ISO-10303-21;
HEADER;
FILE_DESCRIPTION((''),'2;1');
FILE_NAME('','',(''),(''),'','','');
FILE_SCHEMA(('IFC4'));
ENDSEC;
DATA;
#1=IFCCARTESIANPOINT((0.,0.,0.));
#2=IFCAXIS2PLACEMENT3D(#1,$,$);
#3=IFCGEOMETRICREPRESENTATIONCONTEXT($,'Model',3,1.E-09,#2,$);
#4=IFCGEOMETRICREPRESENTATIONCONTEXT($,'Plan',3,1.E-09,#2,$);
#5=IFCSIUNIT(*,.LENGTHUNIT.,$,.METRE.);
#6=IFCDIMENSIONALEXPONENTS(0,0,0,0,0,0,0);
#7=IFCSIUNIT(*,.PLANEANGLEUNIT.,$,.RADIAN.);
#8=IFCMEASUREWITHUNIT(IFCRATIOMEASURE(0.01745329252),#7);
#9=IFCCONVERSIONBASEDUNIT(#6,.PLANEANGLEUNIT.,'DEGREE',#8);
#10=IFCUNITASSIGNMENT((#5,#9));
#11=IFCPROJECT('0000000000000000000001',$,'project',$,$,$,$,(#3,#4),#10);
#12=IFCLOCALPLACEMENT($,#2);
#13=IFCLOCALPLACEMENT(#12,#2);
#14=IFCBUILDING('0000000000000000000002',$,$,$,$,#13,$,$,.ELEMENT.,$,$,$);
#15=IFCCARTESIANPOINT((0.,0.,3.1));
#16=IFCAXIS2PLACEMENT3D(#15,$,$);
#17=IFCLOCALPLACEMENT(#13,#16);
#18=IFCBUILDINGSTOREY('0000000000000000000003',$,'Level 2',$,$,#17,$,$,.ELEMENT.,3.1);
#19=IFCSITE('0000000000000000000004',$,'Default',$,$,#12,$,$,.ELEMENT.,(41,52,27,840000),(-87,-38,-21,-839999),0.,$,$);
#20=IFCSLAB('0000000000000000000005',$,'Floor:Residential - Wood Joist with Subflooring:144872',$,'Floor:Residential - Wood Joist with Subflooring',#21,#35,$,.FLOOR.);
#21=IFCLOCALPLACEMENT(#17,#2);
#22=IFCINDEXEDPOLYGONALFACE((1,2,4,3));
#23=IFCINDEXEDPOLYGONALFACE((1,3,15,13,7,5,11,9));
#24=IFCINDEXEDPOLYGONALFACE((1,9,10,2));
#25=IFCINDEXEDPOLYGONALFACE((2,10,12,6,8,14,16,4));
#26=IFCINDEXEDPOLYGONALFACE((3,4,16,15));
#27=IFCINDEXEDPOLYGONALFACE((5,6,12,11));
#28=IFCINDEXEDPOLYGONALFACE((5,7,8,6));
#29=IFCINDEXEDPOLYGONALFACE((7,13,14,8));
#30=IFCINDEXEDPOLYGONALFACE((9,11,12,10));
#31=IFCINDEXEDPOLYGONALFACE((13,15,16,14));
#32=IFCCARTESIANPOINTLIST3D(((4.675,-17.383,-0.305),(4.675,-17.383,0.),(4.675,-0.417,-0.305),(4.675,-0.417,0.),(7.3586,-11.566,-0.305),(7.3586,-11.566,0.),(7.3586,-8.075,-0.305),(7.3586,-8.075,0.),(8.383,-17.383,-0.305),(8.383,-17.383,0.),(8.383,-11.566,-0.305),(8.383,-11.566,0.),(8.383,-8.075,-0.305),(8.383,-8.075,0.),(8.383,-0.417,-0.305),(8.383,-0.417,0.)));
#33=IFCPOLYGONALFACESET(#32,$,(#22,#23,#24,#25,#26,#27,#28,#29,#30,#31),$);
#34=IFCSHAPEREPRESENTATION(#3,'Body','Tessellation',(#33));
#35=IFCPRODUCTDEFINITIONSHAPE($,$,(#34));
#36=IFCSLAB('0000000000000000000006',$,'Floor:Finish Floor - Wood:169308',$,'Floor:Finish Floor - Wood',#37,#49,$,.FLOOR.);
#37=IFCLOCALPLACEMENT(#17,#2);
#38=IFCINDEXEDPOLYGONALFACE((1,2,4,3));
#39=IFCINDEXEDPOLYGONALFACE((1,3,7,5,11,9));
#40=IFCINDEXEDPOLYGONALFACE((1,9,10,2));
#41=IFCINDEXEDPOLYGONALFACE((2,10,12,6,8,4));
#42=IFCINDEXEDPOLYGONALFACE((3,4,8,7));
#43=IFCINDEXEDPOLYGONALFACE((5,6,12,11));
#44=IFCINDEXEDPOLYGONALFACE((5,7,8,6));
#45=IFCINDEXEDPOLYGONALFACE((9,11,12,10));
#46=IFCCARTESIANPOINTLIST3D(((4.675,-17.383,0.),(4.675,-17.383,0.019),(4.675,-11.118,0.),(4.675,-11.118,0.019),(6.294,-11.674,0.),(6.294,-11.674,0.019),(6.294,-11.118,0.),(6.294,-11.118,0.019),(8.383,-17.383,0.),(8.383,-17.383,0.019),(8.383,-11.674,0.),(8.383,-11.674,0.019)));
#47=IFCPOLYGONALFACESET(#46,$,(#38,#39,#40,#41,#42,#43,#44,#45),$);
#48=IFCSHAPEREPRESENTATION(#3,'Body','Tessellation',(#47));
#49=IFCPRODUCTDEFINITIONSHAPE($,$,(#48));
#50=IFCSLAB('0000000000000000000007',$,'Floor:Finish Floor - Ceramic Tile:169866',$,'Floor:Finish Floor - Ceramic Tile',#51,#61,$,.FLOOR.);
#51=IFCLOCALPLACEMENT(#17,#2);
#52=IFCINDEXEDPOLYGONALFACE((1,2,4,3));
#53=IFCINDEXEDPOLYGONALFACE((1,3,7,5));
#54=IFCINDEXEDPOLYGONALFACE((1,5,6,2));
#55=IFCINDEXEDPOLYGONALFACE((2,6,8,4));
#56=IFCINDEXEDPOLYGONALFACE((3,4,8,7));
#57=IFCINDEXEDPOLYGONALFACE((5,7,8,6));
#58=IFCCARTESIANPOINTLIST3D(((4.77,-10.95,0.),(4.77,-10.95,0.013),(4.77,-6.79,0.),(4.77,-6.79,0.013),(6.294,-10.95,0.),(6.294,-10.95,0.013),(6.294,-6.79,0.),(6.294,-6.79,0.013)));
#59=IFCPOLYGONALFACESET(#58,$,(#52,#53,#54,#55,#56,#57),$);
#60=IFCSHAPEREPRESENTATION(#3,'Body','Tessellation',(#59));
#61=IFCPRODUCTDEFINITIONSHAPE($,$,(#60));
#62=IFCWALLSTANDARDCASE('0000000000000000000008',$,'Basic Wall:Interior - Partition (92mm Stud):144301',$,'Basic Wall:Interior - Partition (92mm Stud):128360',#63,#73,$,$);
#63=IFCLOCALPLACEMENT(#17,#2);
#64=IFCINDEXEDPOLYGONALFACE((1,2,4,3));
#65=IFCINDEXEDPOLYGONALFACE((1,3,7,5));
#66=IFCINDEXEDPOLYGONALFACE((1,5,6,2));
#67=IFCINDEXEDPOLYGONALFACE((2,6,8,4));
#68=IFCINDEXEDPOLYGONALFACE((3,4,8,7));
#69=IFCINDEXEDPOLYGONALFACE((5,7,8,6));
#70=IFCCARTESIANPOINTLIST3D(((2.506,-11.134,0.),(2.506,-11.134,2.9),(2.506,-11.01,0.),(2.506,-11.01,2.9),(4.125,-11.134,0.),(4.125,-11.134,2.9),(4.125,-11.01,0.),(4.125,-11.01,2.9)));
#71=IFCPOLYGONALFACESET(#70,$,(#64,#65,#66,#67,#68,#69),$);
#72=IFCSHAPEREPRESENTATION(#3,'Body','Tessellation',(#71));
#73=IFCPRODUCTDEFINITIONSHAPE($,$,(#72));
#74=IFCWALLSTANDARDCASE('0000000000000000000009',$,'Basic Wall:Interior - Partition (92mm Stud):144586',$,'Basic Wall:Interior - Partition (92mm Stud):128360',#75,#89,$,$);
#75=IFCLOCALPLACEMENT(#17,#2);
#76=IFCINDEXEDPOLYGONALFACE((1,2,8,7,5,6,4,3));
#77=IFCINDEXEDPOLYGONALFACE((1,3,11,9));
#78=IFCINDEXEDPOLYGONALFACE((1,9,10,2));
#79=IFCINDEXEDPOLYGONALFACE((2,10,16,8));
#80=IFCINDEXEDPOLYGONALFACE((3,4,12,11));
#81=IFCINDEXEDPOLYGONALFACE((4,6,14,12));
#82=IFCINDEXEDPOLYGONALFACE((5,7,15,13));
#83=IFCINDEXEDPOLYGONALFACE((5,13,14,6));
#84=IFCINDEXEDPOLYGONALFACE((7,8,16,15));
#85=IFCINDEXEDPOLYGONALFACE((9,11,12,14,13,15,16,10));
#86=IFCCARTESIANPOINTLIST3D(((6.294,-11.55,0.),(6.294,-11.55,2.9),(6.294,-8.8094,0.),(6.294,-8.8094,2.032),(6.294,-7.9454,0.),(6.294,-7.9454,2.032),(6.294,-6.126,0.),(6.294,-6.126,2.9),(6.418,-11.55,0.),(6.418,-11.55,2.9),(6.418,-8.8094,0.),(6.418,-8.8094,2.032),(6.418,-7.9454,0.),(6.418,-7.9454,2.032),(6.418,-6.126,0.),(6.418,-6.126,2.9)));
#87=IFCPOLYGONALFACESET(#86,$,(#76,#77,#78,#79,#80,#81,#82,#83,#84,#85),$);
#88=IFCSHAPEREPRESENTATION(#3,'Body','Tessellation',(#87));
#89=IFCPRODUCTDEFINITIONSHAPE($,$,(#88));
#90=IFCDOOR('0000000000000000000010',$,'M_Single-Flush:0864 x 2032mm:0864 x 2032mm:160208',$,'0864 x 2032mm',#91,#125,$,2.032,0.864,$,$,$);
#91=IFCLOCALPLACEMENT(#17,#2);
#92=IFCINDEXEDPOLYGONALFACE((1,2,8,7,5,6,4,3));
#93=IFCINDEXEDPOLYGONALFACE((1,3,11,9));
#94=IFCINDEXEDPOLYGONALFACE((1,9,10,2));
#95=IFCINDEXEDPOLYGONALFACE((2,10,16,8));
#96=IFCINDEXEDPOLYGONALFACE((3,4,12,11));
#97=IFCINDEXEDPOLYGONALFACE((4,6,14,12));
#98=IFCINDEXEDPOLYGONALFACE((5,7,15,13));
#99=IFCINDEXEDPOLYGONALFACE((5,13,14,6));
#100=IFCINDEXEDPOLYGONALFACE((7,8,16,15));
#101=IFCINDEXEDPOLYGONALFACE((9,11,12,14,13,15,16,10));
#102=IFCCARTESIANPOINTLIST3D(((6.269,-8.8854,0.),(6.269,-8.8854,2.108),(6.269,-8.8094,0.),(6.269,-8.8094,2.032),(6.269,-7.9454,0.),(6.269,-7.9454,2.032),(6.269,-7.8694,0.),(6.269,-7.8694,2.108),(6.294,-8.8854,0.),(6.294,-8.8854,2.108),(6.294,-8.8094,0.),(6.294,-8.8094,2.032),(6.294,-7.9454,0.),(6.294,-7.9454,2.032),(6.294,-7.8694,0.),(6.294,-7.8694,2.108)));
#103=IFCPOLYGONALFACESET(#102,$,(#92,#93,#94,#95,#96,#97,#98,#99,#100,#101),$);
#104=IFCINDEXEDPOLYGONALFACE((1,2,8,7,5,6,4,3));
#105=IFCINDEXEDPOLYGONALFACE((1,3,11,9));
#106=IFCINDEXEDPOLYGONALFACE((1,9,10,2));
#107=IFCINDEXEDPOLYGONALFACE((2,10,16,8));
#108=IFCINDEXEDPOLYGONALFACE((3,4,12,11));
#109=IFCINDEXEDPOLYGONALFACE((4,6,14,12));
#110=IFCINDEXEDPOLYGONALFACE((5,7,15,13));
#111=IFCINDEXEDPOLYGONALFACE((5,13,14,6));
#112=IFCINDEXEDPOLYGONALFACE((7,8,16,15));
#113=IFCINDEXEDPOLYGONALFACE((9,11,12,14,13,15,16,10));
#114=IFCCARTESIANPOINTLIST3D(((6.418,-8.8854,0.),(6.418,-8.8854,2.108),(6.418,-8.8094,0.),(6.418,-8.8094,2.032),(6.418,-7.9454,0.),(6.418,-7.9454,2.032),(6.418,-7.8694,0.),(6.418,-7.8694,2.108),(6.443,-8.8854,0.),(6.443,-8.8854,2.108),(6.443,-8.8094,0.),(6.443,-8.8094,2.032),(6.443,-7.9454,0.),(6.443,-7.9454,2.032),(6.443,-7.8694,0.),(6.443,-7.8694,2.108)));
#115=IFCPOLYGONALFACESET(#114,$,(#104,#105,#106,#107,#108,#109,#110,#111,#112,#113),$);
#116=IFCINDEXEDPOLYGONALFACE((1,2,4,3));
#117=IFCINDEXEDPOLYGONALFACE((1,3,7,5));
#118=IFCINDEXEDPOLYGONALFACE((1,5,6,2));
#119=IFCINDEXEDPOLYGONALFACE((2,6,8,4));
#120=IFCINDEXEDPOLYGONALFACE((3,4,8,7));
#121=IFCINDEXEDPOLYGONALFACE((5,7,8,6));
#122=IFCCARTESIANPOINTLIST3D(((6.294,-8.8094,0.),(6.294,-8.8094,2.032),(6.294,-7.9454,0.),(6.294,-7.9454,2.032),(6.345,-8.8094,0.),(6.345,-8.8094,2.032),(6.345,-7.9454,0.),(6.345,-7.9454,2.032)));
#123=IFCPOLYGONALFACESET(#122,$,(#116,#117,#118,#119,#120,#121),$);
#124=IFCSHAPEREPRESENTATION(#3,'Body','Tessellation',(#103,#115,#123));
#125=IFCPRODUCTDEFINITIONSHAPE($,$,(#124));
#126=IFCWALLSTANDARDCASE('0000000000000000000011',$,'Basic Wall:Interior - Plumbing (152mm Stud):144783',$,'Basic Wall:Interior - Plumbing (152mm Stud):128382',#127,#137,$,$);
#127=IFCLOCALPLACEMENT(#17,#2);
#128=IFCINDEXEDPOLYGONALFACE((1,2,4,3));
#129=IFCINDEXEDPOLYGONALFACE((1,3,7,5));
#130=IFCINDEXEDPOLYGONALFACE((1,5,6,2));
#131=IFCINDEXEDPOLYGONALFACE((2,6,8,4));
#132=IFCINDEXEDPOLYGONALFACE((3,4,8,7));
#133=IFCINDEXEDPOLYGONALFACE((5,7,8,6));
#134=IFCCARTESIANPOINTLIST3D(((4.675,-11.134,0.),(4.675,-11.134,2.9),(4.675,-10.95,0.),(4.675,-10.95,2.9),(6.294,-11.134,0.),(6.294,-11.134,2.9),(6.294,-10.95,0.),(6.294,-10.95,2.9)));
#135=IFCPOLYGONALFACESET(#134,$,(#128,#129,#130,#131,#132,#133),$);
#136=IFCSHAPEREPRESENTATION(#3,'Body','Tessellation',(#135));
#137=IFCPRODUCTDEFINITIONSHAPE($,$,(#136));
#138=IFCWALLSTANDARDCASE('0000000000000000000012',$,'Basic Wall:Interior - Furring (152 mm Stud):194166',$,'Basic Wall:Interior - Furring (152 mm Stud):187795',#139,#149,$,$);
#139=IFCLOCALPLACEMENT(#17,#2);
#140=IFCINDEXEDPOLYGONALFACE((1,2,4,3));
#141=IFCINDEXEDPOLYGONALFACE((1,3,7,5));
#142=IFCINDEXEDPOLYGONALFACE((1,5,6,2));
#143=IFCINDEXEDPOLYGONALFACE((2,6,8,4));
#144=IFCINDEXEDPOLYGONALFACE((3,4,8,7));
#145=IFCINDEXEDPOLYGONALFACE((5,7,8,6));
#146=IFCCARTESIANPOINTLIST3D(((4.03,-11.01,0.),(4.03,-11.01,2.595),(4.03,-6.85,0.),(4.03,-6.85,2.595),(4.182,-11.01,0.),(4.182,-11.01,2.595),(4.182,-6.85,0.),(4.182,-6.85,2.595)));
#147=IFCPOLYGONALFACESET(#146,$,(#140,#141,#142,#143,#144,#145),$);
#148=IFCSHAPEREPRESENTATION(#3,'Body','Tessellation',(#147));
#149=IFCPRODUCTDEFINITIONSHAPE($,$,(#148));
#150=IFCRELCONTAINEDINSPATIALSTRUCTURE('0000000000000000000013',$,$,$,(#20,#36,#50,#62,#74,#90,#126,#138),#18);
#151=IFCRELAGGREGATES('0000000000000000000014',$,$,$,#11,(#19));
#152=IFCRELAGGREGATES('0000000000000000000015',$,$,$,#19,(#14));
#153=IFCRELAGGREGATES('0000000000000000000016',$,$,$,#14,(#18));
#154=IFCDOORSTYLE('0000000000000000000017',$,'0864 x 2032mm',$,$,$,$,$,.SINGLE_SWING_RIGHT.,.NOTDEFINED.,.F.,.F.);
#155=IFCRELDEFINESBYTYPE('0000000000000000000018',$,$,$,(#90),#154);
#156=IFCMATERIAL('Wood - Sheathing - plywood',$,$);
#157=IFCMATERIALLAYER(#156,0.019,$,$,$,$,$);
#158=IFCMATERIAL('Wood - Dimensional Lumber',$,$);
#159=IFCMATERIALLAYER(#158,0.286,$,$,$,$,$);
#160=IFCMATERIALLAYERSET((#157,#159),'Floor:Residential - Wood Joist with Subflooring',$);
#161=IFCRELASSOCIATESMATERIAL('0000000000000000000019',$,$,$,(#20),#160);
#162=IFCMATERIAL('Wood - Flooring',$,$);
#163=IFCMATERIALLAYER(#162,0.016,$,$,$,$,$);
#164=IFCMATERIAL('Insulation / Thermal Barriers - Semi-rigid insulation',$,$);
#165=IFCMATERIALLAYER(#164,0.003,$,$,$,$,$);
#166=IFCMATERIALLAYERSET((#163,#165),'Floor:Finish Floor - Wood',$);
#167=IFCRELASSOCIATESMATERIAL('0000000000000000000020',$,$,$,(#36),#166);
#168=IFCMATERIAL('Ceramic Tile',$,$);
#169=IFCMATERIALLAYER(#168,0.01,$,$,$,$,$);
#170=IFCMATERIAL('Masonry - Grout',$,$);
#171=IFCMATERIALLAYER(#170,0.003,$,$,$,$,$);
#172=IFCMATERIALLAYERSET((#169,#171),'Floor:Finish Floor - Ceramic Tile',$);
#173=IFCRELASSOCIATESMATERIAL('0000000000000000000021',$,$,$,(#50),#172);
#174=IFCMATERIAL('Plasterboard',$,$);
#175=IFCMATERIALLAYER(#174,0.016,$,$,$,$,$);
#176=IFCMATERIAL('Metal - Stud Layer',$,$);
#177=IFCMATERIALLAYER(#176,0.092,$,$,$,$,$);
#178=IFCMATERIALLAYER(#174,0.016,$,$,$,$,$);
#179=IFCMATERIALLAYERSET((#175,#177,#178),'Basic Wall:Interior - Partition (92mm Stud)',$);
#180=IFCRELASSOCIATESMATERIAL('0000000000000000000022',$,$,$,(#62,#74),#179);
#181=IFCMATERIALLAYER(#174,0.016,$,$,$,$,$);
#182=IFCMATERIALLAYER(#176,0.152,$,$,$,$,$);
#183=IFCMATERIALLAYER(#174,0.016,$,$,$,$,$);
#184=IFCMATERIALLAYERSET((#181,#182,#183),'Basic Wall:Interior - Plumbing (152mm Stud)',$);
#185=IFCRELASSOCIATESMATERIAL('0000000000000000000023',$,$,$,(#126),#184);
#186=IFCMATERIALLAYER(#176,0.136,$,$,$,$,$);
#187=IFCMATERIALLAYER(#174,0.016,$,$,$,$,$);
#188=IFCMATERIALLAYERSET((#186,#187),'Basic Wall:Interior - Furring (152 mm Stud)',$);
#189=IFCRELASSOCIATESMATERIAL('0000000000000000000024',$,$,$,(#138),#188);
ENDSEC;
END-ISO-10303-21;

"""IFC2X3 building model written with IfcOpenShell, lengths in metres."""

from ifc_helpers import new_model, entity, si_unit, converted_unit, frame, frame_2d, origin, origin_2d_with_axis, place, context, project, spatial, polyline, rectangle, outline, extrude, source, transform, mapped, material, layer, layer_set, layer_usage, type_object, type_shapes, element, fill, save


model = new_model("IFC2X3")

# Units and contexts
model_context = context("Model", 3, precision=1e-09, world=origin())
plan_context = context("Plan", 3, precision=1e-09, world=origin())
ifc_project = project(units=[si_unit("LENGTHUNIT", "METRE"), converted_unit("PLANEANGLEUNIT", "DEGREE", entity("IfcRatioMeasure", 0.01745329252), si_unit("PLANEANGLEUNIT", "RADIAN"), dimensions=[0, 0, 0, 0, 0, 0, 0])], contexts=[model_context, plan_context])

# Site, building, storey
site_placement = place(None, origin())
site = spatial("IfcSite", under=ifc_project, at=site_placement, Name="Default", CompositionType="ELEMENT", RefLatitude=(41, 52, 27, 840000), RefLongitude=(-87, -38, -21, -839999), RefElevation=0.0)
building_placement = place(site_placement, origin())
building = spatial("IfcBuilding", under=site, at=building_placement, CompositionType="ELEMENT")
storey_placement = place(building_placement, frame((0.0, 0.0, 3.1)))
storey = spatial("IfcBuildingStorey", under=building, at=storey_placement, Name="Level 2", CompositionType="ELEMENT", Elevation=3.1)

# Slabs
ifc_material_1 = material(Name="Wood - Sheathing - plywood")
ifc_layer_1 = layer(ifc_material_1, 0.019)
ifc_material_2 = material(Name="Wood - Dimensional Lumber")
ifc_layer_2 = layer(ifc_material_2, 0.286)
ifc_layer_set_1 = layer_set([ifc_layer_1, ifc_layer_2], Name="Floor:Residential - Wood Joist with Subflooring")
ifc_layer_usage_1 = layer_usage(ifc_layer_set_1, "AXIS3", "POSITIVE", 0.0)
slab_1_placement = place(storey_placement, frame((4.675, -17.383, -0.305)))
element("IfcSlab", 1, at=slab_1_placement, inside=storey, material=ifc_layer_usage_1, Name="Floor:Residential - Wood Joist with Subflooring:144872", ObjectType="Floor:Residential - Wood Joist with Subflooring", PredefinedType="FLOOR", context=model_context, shape_type="SweptSolid", body=[
    extrude(outline(polyline([(-1.854, 8.483), (-1.854, 0.825), (-0.8296, 0.825), (-0.8296, -2.666), (-1.854, -2.666), (-1.854, -8.483), (1.854, -8.483), (1.854, 8.483), (-1.854, 8.483)])), frame((1.854, 8.483, 0.305), z_axis=(0.0, 0.0, -1.0), x_axis=(-1.0, 0.0, 0.0)), (0.0, 0.0, 1.0), 0.305),
])
ifc_material_3 = material(Name="Wood - Flooring")
ifc_layer_3 = layer(ifc_material_3, 0.016)
ifc_material_4 = material(Name="Insulation / Thermal Barriers - Semi-rigid insulation")
ifc_layer_4 = layer(ifc_material_4, 0.003)
ifc_layer_set_2 = layer_set([ifc_layer_3, ifc_layer_4], Name="Floor:Finish Floor - Wood")
ifc_layer_usage_2 = layer_usage(ifc_layer_set_2, "AXIS3", "POSITIVE", 0.0)
slab_2_placement = place(storey_placement, frame((4.675, -17.383, 0.0)))
element("IfcSlab", 2, at=slab_2_placement, inside=storey, material=ifc_layer_usage_2, Name="Floor:Finish Floor - Wood:169308", ObjectType="Floor:Finish Floor - Wood", PredefinedType="FLOOR", context=model_context, shape_type="SweptSolid", body=[
    extrude(outline(polyline([(-1.854, 2.5765), (-1.854, -3.1325), (1.854, -3.1325), (1.854, 3.1325), (0.235, 3.1325), (0.235, 2.5765), (-1.854, 2.5765)])), frame((1.854, 3.1325, 0.019), z_axis=(0.0, 0.0, -1.0), x_axis=(-1.0, 0.0, 0.0)), (0.0, 0.0, 1.0), 0.019),
])
ifc_material_5 = material(Name="Ceramic Tile")
ifc_layer_5 = layer(ifc_material_5, 0.01)
ifc_material_6 = material(Name="Masonry - Grout")
ifc_layer_6 = layer(ifc_material_6, 0.003)
ifc_layer_set_3 = layer_set([ifc_layer_5, ifc_layer_6], Name="Floor:Finish Floor - Ceramic Tile")
ifc_layer_usage_3 = layer_usage(ifc_layer_set_3, "AXIS3", "POSITIVE", 0.0)
slab_3_placement = place(storey_placement, frame((4.77, -10.95, 0.0)))
element("IfcSlab", 3, at=slab_3_placement, inside=storey, material=ifc_layer_usage_3, Name="Floor:Finish Floor - Ceramic Tile:169866", ObjectType="Floor:Finish Floor - Ceramic Tile", PredefinedType="FLOOR", context=model_context, shape_type="SweptSolid", body=[
    extrude(rectangle(XDim=4.16, YDim=1.524, at=frame_2d((0.0, 0.0), x_axis=(0.0, -1.0))), frame((0.762, 2.08, 0.013), z_axis=(0.0, 0.0, -1.0), x_axis=(-1.0, 0.0, 0.0)), (0.0, 0.0, 1.0), 0.013),
])

# Shared definitions
ifc_material_7 = material(Name="Metal - Stud Layer")
ifc_material_8 = material(Name="Plasterboard")

# Wall
ifc_layer_7 = layer(ifc_material_8, 0.016)
ifc_layer_8 = layer(ifc_material_7, 0.092)
ifc_layer_9 = layer(ifc_material_8, 0.016)
ifc_layer_set_4 = layer_set([ifc_layer_7, ifc_layer_8, ifc_layer_9], Name="Basic Wall:Interior - Partition (92mm Stud)")
ifc_layer_usage_4 = layer_usage(ifc_layer_set_4, "AXIS2", "NEGATIVE", 0.062)
wall_1_placement = place(storey_placement, frame((4.125, -11.072, 0.0), z_axis=(0.0, 0.0, 1.0), x_axis=(-1.0, 0.0, 0.0)))
element("IfcWallStandardCase", 4, at=wall_1_placement, inside=storey, material=ifc_layer_usage_4, Name="Basic Wall:Interior - Partition (92mm Stud):144301", ObjectType="Basic Wall:Interior - Partition (92mm Stud):128360", context=model_context, shape_type="SweptSolid", body=[
    extrude(rectangle(XDim=1.619, YDim=0.124, at=frame_2d((0.8095, 0.0), x_axis=(-1.0, 0.0))), origin(), (0.0, 0.0, 1.0), 2.9),
])

# Wall, opening, door
ifc_layer_usage_5 = layer_usage(ifc_layer_set_4, "AXIS2", "NEGATIVE", 0.062)
wall_2_placement = place(storey_placement, frame((6.356, -11.55, 0.0), z_axis=(0.0, 0.0, 1.0), x_axis=(0.0, 1.0, 0.0)))
wall_2 = element("IfcWallStandardCase", 5, at=wall_2_placement, inside=storey, material=ifc_layer_usage_5, Name="Basic Wall:Interior - Partition (92mm Stud):144586", ObjectType="Basic Wall:Interior - Partition (92mm Stud):128360", context=model_context, shape_type="SweptSolid", body=[
    extrude(rectangle(XDim=5.424, YDim=0.124, at=frame_2d((2.712, 0.0), x_axis=(-1.0, 0.0))), origin(), (0.0, 0.0, 1.0), 2.9),
])
opening_1_placement = place(wall_2_placement, frame((2.7406, -0.062, 0.0)))
opening_1 = element("IfcOpeningElement", 6, at=opening_1_placement, cuts=wall_2, ObjectType="Opening", context=model_context, shape_type="SweptSolid", body=[
    extrude(rectangle(XDim=0.864, YDim=2.032, at=frame_2d((1.016, 0.432), x_axis=(0.0, 1.0))), frame((0.0, 0.0, 0.0), z_axis=(0.0, 1.0, 0.0), x_axis=(0.0, 0.0, 1.0)), (0.0, 0.0, 1.0), 0.124),
])
door_style = type_object("IfcDoorStyle", Name="0864 x 2032mm", ConstructionType="NOTDEFINED", OperationType="SINGLE_SWING_RIGHT", ParameterTakesPrecedence=False, Sizeable=False)
shared_shape_1 = source(origin(), model_context, "Body", "SweptSolid", [
    extrude(outline(polyline([(-0.508, -1.073), (0.508, -1.073), (0.508, 1.035), (0.432, 1.035), (0.432, -0.997), (-0.432, -0.997), (-0.432, 1.035), (-0.508, 1.035), (-0.508, -1.073)])), frame((0.432, 0.124, 1.035), z_axis=(0.0, 1.0, 0.0), x_axis=(1.0, 0.0, 0.0)), (0.0, 0.0, 1.0), 0.025),
    extrude(outline(polyline([(-1.073, -0.508), (1.035, -0.508), (1.035, -0.432), (-0.997, -0.432), (-0.997, 0.432), (1.035, 0.432), (1.035, 0.508), (-1.073, 0.508), (-1.073, -0.508)])), frame((0.432, -0.025, 1.035), z_axis=(0.0, 1.0, 0.0), x_axis=(0.0, 0.0, -1.0)), (0.0, 0.0, 1.0), 0.025),
    extrude(rectangle(XDim=0.051, YDim=0.864, at=origin_2d_with_axis()), frame((0.432, 0.0985, 0.0), z_axis=(0.0, 0.0, 1.0), x_axis=(0.0, 1.0, 0.0)), (0.0, 0.0, 1.0), 2.032),
])
type_shapes(door_style, [shared_shape_1])
door_placement = place(opening_1_placement, origin())
door = element("IfcDoor", 7, at=door_placement, inside=storey, type_object=door_style, Name="M_Single-Flush:0864 x 2032mm:0864 x 2032mm:160208", ObjectType="0864 x 2032mm", OverallHeight=2.032, OverallWidth=0.864, context=model_context, shape_type="MappedRepresentation", body=[
    mapped(shared_shape_1, transform((0.0, 0.0, 0.0), scale=1.0)),
])
fill(opening_1, door)

# Walls
ifc_layer_10 = layer(ifc_material_8, 0.016)
ifc_layer_11 = layer(ifc_material_7, 0.152)
ifc_layer_12 = layer(ifc_material_8, 0.016)
ifc_layer_set_5 = layer_set([ifc_layer_10, ifc_layer_11, ifc_layer_12], Name="Basic Wall:Interior - Plumbing (152mm Stud)")
ifc_layer_usage_6 = layer_usage(ifc_layer_set_5, "AXIS2", "NEGATIVE", 0.092)
wall_3_placement = place(storey_placement, frame((6.294, -11.042, 0.0), z_axis=(0.0, 0.0, 1.0), x_axis=(-1.0, 0.0, 0.0)))
element("IfcWallStandardCase", 8, at=wall_3_placement, inside=storey, material=ifc_layer_usage_6, Name="Basic Wall:Interior - Plumbing (152mm Stud):144783", ObjectType="Basic Wall:Interior - Plumbing (152mm Stud):128382", context=model_context, shape_type="SweptSolid", body=[
    extrude(rectangle(XDim=1.619, YDim=0.184, at=frame_2d((0.8095, 0.0), x_axis=(-1.0, 0.0))), origin(), (0.0, 0.0, 1.0), 2.9),
])
ifc_layer_13 = layer(ifc_material_7, 0.136)
ifc_layer_14 = layer(ifc_material_8, 0.016)
ifc_layer_set_6 = layer_set([ifc_layer_13, ifc_layer_14], Name="Basic Wall:Interior - Furring (152 mm Stud)")
ifc_layer_usage_7 = layer_usage(ifc_layer_set_6, "AXIS2", "POSITIVE", -0.076)
wall_4_placement = place(storey_placement, frame((4.106, -11.01, 0.0), z_axis=(0.0, 0.0, 1.0), x_axis=(0.0, 1.0, 0.0)))
element("IfcWallStandardCase", 9, at=wall_4_placement, inside=storey, material=ifc_layer_usage_7, Name="Basic Wall:Interior - Furring (152 mm Stud):194166", ObjectType="Basic Wall:Interior - Furring (152 mm Stud):187795", context=model_context, shape_type="SweptSolid", body=[
    extrude(rectangle(XDim=4.16, YDim=0.152, at=frame_2d((2.08, 0.0), x_axis=(-1.0, 0.0))), origin(), (0.0, 0.0, 1.0), 2.595),
])

save(model, "model.ifc")
